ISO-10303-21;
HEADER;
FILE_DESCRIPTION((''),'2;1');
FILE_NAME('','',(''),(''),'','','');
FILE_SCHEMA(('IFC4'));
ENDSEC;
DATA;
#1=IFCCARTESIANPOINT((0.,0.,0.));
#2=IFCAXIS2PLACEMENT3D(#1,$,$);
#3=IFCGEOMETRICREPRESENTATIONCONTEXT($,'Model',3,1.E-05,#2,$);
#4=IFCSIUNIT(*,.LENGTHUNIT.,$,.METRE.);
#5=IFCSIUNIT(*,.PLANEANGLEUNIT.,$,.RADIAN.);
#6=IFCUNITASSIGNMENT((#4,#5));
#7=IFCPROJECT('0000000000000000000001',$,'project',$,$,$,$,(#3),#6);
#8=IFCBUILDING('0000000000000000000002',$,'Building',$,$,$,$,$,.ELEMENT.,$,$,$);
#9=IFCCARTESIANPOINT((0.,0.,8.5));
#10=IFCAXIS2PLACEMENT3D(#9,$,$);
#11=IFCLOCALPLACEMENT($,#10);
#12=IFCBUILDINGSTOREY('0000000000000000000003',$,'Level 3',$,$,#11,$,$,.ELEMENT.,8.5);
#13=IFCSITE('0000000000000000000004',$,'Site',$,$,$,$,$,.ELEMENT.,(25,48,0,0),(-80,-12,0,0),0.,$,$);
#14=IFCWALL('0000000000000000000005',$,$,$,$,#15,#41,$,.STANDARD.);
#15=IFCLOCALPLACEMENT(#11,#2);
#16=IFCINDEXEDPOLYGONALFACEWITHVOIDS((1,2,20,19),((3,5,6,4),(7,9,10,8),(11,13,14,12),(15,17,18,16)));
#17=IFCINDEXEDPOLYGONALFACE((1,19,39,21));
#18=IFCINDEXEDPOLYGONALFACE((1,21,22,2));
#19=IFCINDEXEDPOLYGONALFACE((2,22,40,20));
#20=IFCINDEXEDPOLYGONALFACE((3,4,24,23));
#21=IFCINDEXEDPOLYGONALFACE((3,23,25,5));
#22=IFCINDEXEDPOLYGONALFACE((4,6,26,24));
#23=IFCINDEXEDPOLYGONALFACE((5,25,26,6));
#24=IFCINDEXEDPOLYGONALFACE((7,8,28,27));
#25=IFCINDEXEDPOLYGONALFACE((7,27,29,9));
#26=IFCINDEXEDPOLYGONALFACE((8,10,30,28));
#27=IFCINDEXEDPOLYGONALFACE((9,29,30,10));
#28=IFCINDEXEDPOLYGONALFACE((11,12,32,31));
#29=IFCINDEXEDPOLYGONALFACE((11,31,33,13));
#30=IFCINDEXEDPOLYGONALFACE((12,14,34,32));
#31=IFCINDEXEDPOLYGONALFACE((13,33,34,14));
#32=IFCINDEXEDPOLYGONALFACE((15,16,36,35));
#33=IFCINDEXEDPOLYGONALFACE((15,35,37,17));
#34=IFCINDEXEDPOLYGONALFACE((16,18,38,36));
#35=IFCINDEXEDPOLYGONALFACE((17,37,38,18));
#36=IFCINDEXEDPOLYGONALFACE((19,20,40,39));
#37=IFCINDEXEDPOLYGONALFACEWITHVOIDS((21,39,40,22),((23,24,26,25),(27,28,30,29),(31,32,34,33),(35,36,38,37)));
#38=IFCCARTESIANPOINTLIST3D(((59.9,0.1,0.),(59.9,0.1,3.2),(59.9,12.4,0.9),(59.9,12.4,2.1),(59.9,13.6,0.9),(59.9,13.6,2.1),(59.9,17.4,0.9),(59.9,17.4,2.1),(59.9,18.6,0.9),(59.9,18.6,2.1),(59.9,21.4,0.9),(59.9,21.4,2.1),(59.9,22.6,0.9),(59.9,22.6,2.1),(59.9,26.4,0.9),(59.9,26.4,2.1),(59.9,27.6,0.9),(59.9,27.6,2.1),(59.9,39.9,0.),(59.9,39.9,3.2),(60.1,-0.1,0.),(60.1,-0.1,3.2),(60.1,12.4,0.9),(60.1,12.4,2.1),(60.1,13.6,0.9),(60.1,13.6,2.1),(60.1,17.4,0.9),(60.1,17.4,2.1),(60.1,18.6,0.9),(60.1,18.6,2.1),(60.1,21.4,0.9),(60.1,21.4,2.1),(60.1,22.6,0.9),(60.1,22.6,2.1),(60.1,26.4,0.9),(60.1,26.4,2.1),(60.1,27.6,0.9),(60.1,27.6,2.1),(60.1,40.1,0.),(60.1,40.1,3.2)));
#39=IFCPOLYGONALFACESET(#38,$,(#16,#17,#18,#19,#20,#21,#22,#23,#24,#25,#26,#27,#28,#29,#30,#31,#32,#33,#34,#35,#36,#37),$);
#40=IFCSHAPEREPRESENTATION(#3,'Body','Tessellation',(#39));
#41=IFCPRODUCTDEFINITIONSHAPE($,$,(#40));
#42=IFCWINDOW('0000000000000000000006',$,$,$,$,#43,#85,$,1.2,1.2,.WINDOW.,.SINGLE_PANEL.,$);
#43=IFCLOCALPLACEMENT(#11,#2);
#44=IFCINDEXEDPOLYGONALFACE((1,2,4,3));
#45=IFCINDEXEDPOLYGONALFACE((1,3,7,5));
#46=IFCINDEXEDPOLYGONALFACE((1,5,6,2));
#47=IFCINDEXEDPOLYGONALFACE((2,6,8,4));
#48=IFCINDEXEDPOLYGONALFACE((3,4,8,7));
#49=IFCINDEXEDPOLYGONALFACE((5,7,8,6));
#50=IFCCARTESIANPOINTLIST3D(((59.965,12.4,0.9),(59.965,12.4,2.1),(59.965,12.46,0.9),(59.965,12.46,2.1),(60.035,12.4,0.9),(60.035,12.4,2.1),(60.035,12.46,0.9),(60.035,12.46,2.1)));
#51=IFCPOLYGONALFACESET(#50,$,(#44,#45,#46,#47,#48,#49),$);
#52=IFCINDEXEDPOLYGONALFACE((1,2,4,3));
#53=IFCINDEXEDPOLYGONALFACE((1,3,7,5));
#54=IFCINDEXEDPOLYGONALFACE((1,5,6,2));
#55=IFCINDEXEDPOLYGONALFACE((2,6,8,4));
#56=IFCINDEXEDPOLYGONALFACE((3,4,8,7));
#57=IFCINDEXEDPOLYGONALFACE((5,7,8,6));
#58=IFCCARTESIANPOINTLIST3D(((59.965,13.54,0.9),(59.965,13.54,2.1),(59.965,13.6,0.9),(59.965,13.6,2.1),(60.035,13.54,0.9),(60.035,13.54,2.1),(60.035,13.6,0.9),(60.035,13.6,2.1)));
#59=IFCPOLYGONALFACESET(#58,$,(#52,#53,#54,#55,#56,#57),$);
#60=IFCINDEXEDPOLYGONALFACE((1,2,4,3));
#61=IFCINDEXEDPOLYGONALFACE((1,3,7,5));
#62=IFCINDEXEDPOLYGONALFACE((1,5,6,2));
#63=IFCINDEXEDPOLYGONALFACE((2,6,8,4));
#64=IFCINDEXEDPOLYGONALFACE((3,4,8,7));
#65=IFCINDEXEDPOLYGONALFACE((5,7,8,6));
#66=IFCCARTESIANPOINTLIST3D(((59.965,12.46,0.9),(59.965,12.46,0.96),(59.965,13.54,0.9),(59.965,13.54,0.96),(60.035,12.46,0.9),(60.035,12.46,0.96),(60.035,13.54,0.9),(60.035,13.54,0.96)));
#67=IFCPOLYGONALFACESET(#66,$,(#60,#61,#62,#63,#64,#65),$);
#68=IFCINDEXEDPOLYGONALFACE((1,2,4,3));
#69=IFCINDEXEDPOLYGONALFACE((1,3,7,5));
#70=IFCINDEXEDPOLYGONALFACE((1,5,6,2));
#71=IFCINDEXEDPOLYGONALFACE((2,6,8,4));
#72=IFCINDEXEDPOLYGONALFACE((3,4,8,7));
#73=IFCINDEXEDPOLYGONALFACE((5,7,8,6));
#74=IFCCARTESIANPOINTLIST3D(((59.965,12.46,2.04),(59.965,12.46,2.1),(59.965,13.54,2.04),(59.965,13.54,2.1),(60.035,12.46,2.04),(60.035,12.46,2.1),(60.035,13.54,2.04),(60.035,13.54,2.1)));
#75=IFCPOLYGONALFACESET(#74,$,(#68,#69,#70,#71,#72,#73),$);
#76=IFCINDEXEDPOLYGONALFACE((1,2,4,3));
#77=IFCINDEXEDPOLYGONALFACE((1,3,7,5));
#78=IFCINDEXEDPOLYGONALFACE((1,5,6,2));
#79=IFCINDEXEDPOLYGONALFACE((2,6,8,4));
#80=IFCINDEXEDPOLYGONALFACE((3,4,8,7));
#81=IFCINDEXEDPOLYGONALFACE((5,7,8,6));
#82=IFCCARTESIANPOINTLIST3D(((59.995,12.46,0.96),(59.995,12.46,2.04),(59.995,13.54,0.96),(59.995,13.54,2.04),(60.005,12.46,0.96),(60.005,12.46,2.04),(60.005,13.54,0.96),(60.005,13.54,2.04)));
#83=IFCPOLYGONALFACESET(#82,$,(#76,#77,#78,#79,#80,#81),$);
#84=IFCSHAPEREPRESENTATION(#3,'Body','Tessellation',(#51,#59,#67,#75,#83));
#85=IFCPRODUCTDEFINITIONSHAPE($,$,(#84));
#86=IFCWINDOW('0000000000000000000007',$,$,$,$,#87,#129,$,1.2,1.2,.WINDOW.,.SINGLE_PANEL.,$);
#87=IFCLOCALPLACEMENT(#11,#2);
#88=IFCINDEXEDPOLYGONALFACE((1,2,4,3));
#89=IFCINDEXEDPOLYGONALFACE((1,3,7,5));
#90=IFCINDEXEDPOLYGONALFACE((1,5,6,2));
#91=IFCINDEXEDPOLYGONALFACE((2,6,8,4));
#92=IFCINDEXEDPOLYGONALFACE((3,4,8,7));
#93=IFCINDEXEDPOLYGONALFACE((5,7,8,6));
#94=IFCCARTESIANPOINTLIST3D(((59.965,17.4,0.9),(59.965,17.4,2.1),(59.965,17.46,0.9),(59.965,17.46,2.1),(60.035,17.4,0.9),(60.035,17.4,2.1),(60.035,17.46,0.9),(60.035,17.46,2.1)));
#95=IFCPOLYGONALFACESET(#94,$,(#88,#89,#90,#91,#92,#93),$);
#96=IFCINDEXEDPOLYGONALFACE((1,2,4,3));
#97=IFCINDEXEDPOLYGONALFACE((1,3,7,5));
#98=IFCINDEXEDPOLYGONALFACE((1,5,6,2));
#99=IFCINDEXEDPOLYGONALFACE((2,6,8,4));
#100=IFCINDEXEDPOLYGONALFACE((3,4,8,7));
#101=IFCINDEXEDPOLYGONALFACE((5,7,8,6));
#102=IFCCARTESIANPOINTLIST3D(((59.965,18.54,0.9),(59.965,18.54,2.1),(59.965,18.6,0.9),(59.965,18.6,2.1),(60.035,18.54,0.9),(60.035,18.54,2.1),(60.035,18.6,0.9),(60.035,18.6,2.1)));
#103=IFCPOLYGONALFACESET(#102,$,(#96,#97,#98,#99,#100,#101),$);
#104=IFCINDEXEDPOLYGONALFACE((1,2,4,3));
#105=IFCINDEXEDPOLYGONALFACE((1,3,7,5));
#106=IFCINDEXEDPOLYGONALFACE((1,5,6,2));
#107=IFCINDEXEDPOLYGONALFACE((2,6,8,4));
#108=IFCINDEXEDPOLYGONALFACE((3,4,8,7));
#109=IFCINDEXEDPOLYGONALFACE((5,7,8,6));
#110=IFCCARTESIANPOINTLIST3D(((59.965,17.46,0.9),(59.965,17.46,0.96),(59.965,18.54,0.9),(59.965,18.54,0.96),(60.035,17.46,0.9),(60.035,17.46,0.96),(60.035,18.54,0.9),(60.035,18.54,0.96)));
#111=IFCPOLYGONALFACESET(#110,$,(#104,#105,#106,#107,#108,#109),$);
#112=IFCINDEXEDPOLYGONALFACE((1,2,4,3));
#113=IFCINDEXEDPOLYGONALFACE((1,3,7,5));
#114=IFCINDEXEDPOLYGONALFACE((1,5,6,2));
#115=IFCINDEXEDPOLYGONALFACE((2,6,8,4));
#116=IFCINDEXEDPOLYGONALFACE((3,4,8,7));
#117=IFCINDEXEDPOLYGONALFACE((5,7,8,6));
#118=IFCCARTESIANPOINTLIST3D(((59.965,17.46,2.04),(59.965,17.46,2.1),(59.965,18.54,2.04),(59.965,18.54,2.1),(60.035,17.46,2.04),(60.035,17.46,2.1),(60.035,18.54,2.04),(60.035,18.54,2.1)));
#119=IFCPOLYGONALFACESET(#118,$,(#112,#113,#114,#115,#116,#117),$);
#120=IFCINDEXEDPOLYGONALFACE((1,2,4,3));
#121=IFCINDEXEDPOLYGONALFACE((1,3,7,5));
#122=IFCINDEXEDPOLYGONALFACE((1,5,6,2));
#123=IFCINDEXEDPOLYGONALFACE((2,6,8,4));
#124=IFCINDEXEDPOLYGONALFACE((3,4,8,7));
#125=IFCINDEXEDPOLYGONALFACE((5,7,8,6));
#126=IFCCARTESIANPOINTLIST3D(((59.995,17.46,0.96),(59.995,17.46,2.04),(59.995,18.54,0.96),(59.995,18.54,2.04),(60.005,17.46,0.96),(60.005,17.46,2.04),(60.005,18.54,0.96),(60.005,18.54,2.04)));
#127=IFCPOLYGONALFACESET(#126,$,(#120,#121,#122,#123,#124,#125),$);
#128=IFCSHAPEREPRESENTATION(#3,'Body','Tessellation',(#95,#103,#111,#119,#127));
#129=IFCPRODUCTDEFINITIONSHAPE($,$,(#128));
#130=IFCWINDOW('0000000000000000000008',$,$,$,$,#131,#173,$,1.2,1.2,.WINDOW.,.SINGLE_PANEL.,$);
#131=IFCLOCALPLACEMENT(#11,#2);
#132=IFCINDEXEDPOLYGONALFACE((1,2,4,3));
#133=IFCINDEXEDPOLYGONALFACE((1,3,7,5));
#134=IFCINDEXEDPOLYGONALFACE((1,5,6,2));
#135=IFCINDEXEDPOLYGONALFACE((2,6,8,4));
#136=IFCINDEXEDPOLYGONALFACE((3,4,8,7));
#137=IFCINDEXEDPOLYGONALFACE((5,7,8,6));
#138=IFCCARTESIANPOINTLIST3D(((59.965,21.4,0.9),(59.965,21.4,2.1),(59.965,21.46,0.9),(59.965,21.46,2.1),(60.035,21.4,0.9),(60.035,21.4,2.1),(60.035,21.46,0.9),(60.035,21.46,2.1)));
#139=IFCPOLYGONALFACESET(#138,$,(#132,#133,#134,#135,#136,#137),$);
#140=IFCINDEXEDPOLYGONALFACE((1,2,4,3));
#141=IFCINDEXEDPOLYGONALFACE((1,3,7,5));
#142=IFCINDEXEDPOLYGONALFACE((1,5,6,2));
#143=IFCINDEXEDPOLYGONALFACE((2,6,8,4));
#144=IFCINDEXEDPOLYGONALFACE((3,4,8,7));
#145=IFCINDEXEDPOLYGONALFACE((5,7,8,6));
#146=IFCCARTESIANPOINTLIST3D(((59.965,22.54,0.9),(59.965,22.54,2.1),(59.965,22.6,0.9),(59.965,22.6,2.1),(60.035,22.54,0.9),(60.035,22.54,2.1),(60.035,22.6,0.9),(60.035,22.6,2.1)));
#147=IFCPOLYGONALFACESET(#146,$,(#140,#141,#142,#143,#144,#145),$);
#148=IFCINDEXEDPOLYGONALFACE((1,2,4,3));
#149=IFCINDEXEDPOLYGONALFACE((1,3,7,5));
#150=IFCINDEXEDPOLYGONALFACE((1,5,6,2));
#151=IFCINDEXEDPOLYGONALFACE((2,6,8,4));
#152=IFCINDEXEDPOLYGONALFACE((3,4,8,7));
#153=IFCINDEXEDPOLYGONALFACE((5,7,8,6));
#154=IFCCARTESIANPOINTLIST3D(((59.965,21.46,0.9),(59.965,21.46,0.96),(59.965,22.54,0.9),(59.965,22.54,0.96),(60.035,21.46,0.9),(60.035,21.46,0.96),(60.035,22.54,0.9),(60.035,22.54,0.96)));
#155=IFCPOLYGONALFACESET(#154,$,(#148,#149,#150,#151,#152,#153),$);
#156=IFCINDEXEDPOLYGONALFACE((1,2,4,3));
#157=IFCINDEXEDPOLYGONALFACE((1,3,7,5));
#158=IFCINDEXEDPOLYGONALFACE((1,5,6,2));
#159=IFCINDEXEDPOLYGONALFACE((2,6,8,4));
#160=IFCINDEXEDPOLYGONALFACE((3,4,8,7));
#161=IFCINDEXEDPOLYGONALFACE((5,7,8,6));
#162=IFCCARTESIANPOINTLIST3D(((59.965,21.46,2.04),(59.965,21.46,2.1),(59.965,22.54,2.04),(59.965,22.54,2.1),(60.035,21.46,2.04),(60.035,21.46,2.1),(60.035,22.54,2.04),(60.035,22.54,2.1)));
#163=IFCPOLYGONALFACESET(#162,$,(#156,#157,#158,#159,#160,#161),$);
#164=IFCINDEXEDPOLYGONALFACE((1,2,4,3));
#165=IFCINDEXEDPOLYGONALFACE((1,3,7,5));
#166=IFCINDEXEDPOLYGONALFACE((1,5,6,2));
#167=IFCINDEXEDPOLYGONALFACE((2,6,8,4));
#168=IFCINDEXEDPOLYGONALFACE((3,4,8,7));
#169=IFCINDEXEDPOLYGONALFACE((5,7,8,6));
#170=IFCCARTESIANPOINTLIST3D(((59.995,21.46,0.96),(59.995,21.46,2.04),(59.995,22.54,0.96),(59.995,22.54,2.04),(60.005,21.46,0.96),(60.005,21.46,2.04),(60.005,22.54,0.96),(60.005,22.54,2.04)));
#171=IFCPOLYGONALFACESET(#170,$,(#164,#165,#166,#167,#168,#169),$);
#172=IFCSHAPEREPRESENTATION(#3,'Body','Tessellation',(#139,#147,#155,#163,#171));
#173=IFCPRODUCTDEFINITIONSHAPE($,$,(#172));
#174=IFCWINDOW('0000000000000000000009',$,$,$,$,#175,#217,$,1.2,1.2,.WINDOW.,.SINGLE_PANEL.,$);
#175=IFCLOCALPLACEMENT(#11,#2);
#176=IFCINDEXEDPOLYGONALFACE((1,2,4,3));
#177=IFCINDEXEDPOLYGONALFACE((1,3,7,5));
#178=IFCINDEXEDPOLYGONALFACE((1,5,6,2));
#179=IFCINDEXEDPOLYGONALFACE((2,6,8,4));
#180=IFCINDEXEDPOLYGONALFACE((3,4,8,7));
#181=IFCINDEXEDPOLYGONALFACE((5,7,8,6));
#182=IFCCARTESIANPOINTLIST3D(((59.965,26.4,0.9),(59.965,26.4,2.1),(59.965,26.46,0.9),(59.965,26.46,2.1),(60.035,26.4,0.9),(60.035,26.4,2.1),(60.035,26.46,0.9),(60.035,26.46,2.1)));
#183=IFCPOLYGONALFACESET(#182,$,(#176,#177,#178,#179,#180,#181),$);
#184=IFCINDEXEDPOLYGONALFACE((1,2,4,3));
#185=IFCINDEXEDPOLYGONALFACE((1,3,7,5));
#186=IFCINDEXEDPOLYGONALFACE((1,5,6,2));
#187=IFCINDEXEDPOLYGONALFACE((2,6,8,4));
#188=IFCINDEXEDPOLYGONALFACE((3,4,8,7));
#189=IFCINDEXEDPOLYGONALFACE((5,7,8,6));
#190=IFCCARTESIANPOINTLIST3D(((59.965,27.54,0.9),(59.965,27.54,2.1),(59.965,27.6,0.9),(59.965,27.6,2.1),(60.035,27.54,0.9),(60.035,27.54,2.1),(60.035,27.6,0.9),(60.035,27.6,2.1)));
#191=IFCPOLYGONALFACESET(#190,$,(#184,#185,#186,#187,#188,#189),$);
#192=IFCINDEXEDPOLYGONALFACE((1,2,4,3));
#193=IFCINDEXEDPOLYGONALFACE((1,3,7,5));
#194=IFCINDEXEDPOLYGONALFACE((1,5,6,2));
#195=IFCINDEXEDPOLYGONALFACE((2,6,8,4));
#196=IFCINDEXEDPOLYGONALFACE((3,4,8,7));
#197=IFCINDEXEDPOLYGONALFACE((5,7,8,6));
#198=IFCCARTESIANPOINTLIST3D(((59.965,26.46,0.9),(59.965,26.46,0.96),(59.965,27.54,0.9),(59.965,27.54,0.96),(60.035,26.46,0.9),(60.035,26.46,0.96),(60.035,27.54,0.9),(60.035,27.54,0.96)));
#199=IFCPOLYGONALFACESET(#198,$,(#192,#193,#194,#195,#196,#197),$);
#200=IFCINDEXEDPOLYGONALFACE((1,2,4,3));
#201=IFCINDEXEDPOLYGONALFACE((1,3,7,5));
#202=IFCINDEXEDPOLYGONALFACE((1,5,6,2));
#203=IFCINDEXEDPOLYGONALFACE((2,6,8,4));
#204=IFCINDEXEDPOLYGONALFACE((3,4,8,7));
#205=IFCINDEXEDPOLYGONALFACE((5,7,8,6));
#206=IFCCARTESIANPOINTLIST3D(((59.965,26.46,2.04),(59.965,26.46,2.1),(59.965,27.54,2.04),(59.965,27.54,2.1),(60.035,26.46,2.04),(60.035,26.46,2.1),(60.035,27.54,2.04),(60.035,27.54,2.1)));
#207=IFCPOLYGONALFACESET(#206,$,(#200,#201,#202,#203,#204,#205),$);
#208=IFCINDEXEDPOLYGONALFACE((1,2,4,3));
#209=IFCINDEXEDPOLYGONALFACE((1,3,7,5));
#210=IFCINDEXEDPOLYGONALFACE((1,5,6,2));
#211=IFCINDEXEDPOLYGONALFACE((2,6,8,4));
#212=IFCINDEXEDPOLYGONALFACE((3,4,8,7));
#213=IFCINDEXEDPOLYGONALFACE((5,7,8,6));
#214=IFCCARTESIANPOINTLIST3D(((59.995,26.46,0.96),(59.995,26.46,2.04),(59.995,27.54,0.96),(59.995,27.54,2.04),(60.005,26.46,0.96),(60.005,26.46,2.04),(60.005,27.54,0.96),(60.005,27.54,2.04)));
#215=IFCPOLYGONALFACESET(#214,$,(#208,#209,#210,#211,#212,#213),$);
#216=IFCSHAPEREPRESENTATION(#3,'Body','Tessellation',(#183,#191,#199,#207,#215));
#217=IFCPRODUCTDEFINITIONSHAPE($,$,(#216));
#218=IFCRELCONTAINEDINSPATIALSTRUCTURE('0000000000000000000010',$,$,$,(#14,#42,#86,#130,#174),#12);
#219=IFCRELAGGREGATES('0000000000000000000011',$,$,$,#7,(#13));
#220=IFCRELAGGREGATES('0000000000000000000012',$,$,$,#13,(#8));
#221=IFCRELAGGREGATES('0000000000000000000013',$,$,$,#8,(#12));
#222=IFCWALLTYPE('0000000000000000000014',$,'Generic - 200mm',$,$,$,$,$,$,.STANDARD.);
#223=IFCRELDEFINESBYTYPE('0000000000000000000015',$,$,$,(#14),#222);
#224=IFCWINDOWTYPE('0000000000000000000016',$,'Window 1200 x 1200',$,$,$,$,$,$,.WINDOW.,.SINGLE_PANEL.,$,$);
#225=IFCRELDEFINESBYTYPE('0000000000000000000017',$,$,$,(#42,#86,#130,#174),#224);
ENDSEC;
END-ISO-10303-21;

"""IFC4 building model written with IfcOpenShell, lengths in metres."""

from ifc_helpers import new_model, si_unit, frame, frame_2d, origin, origin_with_axes, origin_2d, place, context, project, spatial, polyline, rectangle, outline, extrude, type_object, element, fill, save


model = new_model("IFC4")

# Units and contexts
model_context = context("Model", 3, precision=1e-05, world=origin())
ifc_project = project(units=[si_unit("LENGTHUNIT", "METRE"), si_unit("PLANEANGLEUNIT", "RADIAN")], contexts=[model_context])

# Site, building, storey
site = spatial("IfcSite", under=ifc_project, Name="Site", CompositionType="ELEMENT", RefLatitude=(25, 48, 0, 0), RefLongitude=(-80, -12, 0, 0), RefElevation=0.0)
building = spatial("IfcBuilding", under=site, Name="Building", CompositionType="ELEMENT")
storey_placement = place(None, frame((0.0, 0.0, 8.5)))
storey = spatial("IfcBuildingStorey", under=building, at=storey_placement, Name="Level 3", CompositionType="ELEMENT", Elevation=8.5)

# Wall, openings, windows
wall_type = type_object("IfcWallType", Name="Generic - 200mm", PredefinedType="STANDARD")
wall_1_placement = place(None, frame((60.0, 0.0, 8.5), z_axis=(0.0, 0.0, 1.0), x_axis=(0.0, 1.0, 0.0)))
wall_1 = element("IfcWall", 1, at=wall_1_placement, inside=storey, type_object=wall_type, PredefinedType="STANDARD", context=model_context, shape_type="SweptSolid", body=[
    extrude(outline(polyline([(-0.1, -0.1), (40.1, -0.1), (39.9, 0.1), (0.1, 0.1), (-0.1, -0.1)])), origin(), (0.0, 0.0, 1.0), 3.2),
])
opening_1_placement = place(wall_1_placement, frame((13.0, 0.0, 0.9), z_axis=(0.0, 0.0, 1.0), x_axis=(1.0, 0.0, 0.0)))
opening_1 = element("IfcOpeningElement", 2, at=opening_1_placement, cuts=wall_1, PredefinedType="OPENING", context=model_context, shape_type="SweptSolid", body=[
    extrude(rectangle(XDim=1.2, YDim=0.202, at=origin_2d()), origin(), (0.0, 0.0, 1.0), 1.2),
])
opening_2_placement = place(wall_1_placement, frame((18.0, 0.0, 0.9), z_axis=(0.0, 0.0, 1.0), x_axis=(1.0, 0.0, 0.0)))
opening_2 = element("IfcOpeningElement", 3, at=opening_2_placement, cuts=wall_1, PredefinedType="OPENING", context=model_context, shape_type="SweptSolid", body=[
    extrude(rectangle(XDim=1.2, YDim=0.202, at=origin_2d()), origin(), (0.0, 0.0, 1.0), 1.2),
])
opening_3_placement = place(wall_1_placement, frame((22.0, 0.0, 0.9), z_axis=(0.0, 0.0, 1.0), x_axis=(1.0, 0.0, 0.0)))
opening_3 = element("IfcOpeningElement", 4, at=opening_3_placement, cuts=wall_1, PredefinedType="OPENING", context=model_context, shape_type="SweptSolid", body=[
    extrude(rectangle(XDim=1.2, YDim=0.202, at=origin_2d()), origin(), (0.0, 0.0, 1.0), 1.2),
])
opening_4_placement = place(wall_1_placement, frame((27.0, 0.0, 0.9), z_axis=(0.0, 0.0, 1.0), x_axis=(1.0, 0.0, 0.0)))
opening_4 = element("IfcOpeningElement", 5, at=opening_4_placement, cuts=wall_1, PredefinedType="OPENING", context=model_context, shape_type="SweptSolid", body=[
    extrude(rectangle(XDim=1.2, YDim=0.202, at=origin_2d()), origin(), (0.0, 0.0, 1.0), 1.2),
])
window_type = type_object("IfcWindowType", Name="Window 1200 x 1200", PartitioningType="SINGLE_PANEL", PredefinedType="WINDOW")
window_1_placement = place(opening_1_placement, origin_with_axes())
window_1 = element("IfcWindow", 6, at=window_1_placement, inside=storey, type_object=window_type, OverallHeight=1.2, OverallWidth=1.2, PartitioningType="SINGLE_PANEL", PredefinedType="WINDOW", context=model_context, shape_type="SweptSolid", body=[
    extrude(rectangle(XDim=0.06, YDim=0.07, at=frame_2d((-0.57, 0.0))), origin(), (0.0, 0.0, 1.0), 1.2),
    extrude(rectangle(XDim=0.06, YDim=0.07, at=frame_2d((0.57, 0.0))), origin(), (0.0, 0.0, 1.0), 1.2),
    extrude(rectangle(XDim=1.08, YDim=0.07, at=origin_2d()), origin(), (0.0, 0.0, 1.0), 0.06),
    extrude(rectangle(XDim=1.08, YDim=0.07, at=origin_2d()), frame((0.0, 0.0, 1.14)), (0.0, 0.0, 1.0), 0.06),
    extrude(rectangle(XDim=1.08, YDim=0.01, at=origin_2d()), frame((0.0, 0.0, 0.06)), (0.0, 0.0, 1.0), 1.08),
])
fill(opening_1, window_1)
window_2_placement = place(opening_2_placement, origin_with_axes())
window_2 = element("IfcWindow", 7, at=window_2_placement, inside=storey, type_object=window_type, OverallHeight=1.2, OverallWidth=1.2, PartitioningType="SINGLE_PANEL", PredefinedType="WINDOW", context=model_context, shape_type="SweptSolid", body=[
    extrude(rectangle(XDim=0.06, YDim=0.07, at=frame_2d((-0.57, 0.0))), origin(), (0.0, 0.0, 1.0), 1.2),
    extrude(rectangle(XDim=0.06, YDim=0.07, at=frame_2d((0.57, 0.0))), origin(), (0.0, 0.0, 1.0), 1.2),
    extrude(rectangle(XDim=1.08, YDim=0.07, at=origin_2d()), origin(), (0.0, 0.0, 1.0), 0.06),
    extrude(rectangle(XDim=1.08, YDim=0.07, at=origin_2d()), frame((0.0, 0.0, 1.14)), (0.0, 0.0, 1.0), 0.06),
    extrude(rectangle(XDim=1.08, YDim=0.01, at=origin_2d()), frame((0.0, 0.0, 0.06)), (0.0, 0.0, 1.0), 1.08),
])
fill(opening_2, window_2)
window_3_placement = place(opening_3_placement, origin_with_axes())
window_3 = element("IfcWindow", 8, at=window_3_placement, inside=storey, type_object=window_type, OverallHeight=1.2, OverallWidth=1.2, PartitioningType="SINGLE_PANEL", PredefinedType="WINDOW", context=model_context, shape_type="SweptSolid", body=[
    extrude(rectangle(XDim=0.06, YDim=0.07, at=frame_2d((-0.57, 0.0))), origin(), (0.0, 0.0, 1.0), 1.2),
    extrude(rectangle(XDim=0.06, YDim=0.07, at=frame_2d((0.57, 0.0))), origin(), (0.0, 0.0, 1.0), 1.2),
    extrude(rectangle(XDim=1.08, YDim=0.07, at=origin_2d()), origin(), (0.0, 0.0, 1.0), 0.06),
    extrude(rectangle(XDim=1.08, YDim=0.07, at=origin_2d()), frame((0.0, 0.0, 1.14)), (0.0, 0.0, 1.0), 0.06),
    extrude(rectangle(XDim=1.08, YDim=0.01, at=origin_2d()), frame((0.0, 0.0, 0.06)), (0.0, 0.0, 1.0), 1.08),
])
fill(opening_3, window_3)
window_4_placement = place(opening_4_placement, origin_with_axes())
window_4 = element("IfcWindow", 9, at=window_4_placement, inside=storey, type_object=window_type, OverallHeight=1.2, OverallWidth=1.2, PartitioningType="SINGLE_PANEL", PredefinedType="WINDOW", context=model_context, shape_type="SweptSolid", body=[
    extrude(rectangle(XDim=0.06, YDim=0.07, at=frame_2d((-0.57, 0.0))), origin(), (0.0, 0.0, 1.0), 1.2),
    extrude(rectangle(XDim=0.06, YDim=0.07, at=frame_2d((0.57, 0.0))), origin(), (0.0, 0.0, 1.0), 1.2),
    extrude(rectangle(XDim=1.08, YDim=0.07, at=origin_2d()), origin(), (0.0, 0.0, 1.0), 0.06),
    extrude(rectangle(XDim=1.08, YDim=0.07, at=origin_2d()), frame((0.0, 0.0, 1.14)), (0.0, 0.0, 1.0), 0.06),
    extrude(rectangle(XDim=1.08, YDim=0.01, at=origin_2d()), frame((0.0, 0.0, 0.06)), (0.0, 0.0, 1.0), 1.08),
])
fill(opening_4, window_4)

save(model, "model.ifc")
